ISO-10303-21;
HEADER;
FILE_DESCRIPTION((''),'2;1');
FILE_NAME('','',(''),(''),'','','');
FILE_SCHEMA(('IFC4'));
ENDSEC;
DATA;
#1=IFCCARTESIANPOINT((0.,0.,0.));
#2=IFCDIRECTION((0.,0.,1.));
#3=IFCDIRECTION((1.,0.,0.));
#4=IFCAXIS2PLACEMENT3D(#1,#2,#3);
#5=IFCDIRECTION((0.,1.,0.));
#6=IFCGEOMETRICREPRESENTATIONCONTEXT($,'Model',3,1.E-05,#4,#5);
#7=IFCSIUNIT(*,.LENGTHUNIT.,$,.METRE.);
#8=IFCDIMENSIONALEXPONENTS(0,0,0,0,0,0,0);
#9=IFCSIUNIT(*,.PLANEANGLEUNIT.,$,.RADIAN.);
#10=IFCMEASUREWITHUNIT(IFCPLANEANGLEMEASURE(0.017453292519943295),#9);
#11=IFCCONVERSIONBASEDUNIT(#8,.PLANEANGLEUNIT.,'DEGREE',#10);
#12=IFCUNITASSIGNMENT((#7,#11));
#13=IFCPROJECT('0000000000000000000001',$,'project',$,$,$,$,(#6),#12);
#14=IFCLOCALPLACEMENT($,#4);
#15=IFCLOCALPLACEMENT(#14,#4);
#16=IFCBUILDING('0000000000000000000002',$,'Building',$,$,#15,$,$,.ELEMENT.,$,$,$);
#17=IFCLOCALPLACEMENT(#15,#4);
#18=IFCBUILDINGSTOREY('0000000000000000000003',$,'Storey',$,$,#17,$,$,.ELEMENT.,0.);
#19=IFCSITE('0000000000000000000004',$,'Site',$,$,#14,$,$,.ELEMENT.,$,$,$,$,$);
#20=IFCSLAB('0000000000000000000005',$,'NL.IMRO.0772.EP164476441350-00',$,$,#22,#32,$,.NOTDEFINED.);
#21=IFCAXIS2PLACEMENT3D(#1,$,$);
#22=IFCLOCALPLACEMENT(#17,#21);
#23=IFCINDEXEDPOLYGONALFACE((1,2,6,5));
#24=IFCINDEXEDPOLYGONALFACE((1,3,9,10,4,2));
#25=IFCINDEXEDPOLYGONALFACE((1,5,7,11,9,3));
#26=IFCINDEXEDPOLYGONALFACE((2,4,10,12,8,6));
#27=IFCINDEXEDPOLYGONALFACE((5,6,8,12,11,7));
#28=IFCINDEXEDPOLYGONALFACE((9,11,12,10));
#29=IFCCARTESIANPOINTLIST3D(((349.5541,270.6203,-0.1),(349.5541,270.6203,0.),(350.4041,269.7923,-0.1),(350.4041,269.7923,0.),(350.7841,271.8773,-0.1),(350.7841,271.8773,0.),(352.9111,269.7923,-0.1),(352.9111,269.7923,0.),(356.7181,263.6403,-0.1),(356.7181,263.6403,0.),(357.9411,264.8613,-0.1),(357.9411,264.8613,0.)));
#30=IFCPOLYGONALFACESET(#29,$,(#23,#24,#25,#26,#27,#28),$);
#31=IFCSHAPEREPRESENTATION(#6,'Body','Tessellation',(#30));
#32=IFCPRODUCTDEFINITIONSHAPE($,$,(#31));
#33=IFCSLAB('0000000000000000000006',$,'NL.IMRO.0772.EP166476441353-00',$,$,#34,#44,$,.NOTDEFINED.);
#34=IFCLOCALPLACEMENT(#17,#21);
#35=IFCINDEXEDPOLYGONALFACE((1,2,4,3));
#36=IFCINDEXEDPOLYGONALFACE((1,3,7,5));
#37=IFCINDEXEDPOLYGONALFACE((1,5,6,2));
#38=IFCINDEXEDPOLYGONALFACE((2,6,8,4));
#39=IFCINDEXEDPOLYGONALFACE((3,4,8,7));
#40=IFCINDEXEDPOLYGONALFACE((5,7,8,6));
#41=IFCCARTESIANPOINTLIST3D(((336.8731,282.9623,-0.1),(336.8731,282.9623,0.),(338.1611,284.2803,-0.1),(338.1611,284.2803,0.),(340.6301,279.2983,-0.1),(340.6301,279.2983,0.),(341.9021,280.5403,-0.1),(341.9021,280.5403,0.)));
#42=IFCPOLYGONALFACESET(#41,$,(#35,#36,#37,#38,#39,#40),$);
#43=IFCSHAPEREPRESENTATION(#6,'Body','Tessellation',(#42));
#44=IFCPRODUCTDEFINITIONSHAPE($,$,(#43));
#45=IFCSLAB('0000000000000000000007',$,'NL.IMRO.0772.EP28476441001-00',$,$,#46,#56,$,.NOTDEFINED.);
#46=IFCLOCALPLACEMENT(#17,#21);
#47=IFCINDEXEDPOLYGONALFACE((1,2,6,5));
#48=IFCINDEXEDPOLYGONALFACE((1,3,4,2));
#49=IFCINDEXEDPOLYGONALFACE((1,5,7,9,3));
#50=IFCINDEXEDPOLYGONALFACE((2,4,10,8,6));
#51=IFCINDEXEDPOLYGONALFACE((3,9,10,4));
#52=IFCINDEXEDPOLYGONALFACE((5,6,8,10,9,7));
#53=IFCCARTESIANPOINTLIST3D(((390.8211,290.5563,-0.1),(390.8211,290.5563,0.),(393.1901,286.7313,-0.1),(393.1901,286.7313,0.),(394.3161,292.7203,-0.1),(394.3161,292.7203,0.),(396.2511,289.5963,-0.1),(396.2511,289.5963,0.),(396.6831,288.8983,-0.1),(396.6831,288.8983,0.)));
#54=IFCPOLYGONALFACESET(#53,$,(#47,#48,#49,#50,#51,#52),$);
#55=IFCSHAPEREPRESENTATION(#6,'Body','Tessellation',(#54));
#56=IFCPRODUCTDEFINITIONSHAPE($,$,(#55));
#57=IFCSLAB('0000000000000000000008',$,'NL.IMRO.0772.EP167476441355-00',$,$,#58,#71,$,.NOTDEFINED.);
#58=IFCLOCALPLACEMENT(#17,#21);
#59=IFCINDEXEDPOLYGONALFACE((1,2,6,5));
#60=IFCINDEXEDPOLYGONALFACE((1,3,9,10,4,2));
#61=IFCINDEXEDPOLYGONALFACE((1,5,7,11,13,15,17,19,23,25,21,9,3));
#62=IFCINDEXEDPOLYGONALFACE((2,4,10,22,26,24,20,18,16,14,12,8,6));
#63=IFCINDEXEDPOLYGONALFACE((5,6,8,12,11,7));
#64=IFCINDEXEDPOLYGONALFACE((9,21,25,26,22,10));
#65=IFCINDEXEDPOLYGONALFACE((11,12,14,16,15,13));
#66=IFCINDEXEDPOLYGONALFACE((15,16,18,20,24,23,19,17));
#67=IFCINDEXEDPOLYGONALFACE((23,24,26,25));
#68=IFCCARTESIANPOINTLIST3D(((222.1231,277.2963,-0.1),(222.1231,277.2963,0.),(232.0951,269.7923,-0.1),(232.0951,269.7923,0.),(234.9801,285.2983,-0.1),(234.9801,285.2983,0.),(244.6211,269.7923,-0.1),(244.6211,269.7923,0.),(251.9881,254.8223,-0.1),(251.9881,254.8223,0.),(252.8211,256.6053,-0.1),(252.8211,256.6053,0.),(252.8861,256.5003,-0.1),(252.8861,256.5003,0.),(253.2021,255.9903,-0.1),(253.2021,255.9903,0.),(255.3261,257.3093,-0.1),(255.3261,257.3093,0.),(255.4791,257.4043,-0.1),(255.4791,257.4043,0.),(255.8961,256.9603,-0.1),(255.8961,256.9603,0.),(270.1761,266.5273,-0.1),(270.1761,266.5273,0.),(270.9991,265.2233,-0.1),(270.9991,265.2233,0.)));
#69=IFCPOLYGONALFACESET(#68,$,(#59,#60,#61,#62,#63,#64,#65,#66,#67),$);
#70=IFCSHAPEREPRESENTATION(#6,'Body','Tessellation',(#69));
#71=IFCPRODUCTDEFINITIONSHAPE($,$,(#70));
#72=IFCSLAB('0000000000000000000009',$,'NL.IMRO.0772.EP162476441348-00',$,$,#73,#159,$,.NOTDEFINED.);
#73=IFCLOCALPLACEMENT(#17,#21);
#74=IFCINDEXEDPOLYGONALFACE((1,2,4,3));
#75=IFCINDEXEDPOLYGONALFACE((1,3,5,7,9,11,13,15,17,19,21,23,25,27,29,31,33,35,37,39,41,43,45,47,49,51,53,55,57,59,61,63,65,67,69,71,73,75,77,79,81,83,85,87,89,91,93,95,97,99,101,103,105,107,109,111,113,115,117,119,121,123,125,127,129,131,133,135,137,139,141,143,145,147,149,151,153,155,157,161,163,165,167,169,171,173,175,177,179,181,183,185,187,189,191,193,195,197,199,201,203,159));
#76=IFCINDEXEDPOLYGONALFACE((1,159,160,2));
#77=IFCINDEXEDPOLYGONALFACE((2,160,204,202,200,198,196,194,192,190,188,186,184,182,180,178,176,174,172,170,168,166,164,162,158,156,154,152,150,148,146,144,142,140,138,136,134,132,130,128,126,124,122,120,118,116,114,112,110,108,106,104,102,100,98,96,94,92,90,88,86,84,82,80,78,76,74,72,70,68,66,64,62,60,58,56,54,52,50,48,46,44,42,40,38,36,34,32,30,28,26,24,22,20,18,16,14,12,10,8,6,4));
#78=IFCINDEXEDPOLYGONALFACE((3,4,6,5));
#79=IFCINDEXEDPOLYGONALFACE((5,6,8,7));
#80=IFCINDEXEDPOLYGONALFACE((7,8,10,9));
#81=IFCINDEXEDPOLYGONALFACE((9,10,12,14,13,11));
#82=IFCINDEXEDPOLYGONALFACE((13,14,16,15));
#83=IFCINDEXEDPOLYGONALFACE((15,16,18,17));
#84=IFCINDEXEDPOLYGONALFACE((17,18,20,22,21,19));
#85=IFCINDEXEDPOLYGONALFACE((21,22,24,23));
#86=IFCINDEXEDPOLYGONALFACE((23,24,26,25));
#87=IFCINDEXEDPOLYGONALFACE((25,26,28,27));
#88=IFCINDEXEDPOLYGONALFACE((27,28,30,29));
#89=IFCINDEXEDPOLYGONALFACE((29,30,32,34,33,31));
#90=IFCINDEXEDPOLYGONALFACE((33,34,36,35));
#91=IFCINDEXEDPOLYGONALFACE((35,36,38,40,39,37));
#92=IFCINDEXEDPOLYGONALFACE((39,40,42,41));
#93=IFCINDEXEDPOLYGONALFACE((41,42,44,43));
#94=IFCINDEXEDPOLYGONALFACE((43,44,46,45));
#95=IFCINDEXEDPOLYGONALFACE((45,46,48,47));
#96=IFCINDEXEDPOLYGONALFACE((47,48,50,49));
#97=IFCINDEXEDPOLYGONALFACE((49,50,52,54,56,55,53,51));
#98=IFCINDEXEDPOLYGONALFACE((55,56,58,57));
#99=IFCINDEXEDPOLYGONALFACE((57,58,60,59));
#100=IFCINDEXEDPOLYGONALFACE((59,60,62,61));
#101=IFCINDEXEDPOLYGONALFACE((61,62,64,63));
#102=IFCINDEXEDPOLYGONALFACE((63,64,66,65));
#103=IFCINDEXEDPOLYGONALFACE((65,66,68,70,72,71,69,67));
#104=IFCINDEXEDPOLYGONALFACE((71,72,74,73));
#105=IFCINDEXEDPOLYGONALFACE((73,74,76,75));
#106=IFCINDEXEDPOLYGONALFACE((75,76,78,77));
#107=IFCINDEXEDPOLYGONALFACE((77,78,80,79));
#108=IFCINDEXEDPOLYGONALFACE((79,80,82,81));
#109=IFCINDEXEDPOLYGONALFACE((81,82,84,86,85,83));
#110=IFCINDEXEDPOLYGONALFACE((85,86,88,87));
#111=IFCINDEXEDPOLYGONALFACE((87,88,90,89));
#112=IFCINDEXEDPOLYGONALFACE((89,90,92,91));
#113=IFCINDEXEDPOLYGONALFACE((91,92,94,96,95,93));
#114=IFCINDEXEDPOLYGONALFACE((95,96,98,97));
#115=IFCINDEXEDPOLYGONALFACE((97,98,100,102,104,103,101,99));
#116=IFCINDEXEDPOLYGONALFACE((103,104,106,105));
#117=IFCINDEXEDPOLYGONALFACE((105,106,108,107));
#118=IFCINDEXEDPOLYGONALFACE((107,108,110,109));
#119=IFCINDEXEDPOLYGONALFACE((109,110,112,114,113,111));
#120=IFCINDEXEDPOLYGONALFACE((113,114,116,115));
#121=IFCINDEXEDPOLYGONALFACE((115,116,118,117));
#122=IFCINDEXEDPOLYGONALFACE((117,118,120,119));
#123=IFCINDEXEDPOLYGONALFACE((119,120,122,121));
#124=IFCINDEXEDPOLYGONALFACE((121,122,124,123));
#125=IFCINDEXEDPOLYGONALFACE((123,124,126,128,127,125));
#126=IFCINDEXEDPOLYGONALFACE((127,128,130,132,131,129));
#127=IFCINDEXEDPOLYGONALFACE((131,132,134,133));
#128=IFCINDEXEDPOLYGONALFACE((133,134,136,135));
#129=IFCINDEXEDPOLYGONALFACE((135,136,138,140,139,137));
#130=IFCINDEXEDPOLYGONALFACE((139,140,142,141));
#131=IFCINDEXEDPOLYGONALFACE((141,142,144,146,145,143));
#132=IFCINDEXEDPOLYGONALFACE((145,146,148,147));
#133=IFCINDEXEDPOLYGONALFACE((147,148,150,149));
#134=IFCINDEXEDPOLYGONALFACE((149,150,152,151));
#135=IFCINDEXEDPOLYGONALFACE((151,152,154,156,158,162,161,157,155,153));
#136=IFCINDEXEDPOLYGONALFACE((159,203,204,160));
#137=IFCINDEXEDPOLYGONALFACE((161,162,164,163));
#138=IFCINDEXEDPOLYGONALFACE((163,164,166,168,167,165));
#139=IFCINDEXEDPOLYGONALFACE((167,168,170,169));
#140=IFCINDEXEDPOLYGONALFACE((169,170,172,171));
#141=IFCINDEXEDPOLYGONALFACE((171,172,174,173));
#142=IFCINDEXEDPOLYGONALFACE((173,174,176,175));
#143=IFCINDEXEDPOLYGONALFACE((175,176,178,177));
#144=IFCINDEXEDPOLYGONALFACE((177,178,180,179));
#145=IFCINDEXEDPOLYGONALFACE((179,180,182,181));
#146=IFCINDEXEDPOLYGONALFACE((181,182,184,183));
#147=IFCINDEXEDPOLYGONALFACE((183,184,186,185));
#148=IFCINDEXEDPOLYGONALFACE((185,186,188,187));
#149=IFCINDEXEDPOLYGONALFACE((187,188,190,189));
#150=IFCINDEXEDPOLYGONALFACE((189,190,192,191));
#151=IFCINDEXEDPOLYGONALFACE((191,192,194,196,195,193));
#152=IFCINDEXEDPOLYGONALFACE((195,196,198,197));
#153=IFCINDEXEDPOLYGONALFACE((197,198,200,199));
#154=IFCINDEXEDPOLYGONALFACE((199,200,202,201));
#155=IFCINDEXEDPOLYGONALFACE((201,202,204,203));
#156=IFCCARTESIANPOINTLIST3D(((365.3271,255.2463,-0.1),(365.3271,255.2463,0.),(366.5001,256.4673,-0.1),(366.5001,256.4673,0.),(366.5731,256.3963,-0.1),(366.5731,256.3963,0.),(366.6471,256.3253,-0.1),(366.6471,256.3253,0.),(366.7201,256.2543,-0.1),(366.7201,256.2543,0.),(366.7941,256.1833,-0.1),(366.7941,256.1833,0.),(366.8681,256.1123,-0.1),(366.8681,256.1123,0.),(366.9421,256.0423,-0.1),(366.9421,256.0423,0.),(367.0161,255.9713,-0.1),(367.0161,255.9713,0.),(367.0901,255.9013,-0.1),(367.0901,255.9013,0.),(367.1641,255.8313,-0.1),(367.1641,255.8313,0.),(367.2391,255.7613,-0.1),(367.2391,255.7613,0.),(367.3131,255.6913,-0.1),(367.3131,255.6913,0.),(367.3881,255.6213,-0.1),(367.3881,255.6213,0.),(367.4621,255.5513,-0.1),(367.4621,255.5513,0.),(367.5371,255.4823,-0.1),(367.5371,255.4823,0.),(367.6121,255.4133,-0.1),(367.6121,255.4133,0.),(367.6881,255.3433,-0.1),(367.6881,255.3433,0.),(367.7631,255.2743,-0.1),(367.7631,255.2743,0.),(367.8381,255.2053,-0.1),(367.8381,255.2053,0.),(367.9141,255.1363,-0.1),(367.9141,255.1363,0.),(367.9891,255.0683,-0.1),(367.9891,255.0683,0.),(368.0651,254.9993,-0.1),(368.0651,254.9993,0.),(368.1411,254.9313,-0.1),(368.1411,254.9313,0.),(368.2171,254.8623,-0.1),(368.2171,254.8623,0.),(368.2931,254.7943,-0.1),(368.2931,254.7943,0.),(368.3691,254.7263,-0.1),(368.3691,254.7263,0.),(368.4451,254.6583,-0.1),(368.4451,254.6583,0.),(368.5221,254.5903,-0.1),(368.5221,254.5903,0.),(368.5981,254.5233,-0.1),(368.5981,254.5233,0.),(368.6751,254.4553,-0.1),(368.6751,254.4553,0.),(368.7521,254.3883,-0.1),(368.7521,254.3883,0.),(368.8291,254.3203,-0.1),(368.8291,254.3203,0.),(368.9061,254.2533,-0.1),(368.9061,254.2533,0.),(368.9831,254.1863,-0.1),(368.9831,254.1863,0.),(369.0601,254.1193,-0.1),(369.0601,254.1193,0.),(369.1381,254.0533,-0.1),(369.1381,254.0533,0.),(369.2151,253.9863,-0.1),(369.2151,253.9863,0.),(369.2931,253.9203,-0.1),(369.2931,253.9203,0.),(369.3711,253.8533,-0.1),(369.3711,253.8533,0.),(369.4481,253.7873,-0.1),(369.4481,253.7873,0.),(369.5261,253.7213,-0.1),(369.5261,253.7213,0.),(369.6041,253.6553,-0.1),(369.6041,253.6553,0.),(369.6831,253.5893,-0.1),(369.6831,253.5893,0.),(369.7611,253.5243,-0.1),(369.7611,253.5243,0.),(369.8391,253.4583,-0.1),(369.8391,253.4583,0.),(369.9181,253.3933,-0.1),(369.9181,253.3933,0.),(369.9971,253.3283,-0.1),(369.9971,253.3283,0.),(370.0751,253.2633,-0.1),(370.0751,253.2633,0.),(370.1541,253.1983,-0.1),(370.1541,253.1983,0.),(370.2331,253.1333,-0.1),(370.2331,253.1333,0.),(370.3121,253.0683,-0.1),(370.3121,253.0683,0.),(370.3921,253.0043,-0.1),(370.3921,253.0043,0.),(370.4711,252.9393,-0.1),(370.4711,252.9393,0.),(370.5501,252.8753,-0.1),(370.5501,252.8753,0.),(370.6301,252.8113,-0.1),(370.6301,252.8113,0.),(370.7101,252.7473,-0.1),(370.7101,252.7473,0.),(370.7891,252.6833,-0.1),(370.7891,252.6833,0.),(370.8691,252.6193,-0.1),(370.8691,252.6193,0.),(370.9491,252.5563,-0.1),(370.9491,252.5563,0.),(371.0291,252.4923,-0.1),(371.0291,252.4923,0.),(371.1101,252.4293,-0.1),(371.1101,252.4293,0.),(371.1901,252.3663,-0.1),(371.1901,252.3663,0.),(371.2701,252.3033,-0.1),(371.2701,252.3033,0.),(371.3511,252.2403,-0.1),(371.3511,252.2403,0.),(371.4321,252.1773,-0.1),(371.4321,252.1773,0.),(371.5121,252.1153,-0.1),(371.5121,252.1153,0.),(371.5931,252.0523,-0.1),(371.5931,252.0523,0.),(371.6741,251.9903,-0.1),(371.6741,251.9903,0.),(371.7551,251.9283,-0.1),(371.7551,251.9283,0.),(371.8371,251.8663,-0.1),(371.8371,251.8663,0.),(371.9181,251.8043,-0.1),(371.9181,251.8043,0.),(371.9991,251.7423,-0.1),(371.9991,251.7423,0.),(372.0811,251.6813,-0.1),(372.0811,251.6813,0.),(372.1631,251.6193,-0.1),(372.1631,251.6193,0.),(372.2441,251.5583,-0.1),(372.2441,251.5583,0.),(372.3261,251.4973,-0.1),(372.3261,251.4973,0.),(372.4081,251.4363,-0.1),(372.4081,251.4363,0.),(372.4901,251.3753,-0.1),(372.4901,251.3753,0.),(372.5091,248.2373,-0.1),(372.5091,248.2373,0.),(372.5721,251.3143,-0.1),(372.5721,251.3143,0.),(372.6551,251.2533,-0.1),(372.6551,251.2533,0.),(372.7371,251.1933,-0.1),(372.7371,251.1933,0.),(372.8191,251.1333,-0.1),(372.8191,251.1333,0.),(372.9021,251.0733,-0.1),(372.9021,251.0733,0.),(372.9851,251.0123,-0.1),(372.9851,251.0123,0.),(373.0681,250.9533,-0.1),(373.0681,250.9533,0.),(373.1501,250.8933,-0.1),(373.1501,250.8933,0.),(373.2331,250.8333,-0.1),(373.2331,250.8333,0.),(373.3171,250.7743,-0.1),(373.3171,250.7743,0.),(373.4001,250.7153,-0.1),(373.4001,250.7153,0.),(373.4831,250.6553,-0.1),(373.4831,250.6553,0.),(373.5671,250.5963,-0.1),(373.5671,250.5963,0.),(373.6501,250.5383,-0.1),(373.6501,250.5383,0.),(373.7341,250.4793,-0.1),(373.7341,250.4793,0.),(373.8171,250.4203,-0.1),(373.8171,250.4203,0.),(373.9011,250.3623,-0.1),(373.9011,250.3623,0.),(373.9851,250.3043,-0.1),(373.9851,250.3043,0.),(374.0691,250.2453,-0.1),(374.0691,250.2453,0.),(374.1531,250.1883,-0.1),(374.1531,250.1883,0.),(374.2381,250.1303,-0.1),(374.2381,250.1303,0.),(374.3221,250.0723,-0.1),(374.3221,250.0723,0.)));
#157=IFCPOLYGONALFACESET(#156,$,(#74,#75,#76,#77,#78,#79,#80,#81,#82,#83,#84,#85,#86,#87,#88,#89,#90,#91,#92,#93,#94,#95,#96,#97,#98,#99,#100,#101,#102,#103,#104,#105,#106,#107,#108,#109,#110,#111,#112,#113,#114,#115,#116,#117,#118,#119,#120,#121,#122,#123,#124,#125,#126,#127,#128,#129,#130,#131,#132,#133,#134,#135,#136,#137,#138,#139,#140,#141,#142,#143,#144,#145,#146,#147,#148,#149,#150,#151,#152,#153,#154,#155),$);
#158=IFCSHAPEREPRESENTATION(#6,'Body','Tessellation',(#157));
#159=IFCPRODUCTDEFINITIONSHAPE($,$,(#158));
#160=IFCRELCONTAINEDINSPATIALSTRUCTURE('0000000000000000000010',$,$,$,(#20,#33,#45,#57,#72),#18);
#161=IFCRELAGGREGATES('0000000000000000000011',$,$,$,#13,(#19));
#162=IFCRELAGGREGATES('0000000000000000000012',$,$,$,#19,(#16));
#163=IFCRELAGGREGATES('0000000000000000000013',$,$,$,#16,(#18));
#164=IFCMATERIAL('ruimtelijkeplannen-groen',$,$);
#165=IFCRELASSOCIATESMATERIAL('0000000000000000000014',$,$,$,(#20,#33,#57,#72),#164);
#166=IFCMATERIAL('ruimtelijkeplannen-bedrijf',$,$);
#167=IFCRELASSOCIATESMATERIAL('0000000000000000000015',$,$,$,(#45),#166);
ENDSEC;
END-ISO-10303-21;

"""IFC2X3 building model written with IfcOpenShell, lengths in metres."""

from ifc_helpers import new_model, entity, si_unit, converted_unit, direction, frame, origin_with_axes, place, context, project, spatial, polyline, outline, extrude, material, element, save


model = new_model("IFC2X3")

# Units and contexts
model_context = context("Model", 3, precision=1e-05, world=origin_with_axes(), true_north=direction((0.0, 1.0, 0.0)))
ifc_project = project(units=[si_unit("LENGTHUNIT", "METRE"), converted_unit("PLANEANGLEUNIT", "DEGREE", entity("IfcPlaneAngleMeasure", 0.017453292519943295), si_unit("PLANEANGLEUNIT", "RADIAN"), dimensions=[0, 0, 0, 0, 0, 0, 0])], contexts=[model_context])

# Site, building, storey
site_placement = place(None, origin_with_axes())
site = spatial("IfcSite", under=ifc_project, at=site_placement, Name="Site", CompositionType="ELEMENT")
building_placement = place(site_placement, origin_with_axes())
building = spatial("IfcBuilding", under=site, at=building_placement, Name="Building", CompositionType="ELEMENT")
storey_placement = place(building_placement, origin_with_axes())
storey = spatial("IfcBuildingStorey", under=building, at=storey_placement, Name="Storey", CompositionType="ELEMENT", Elevation=0.0)

# Slabs
ifc_material_1 = material(Name="ruimtelijkeplannen-groen")
slab_1_placement = place(storey_placement, frame((0.0, 0.0, -0.1), z_axis=(0.0, 0.0, 1.0), x_axis=(1.0, 0.0, 0.0)))
element("IfcSlab", 1, at=slab_1_placement, inside=storey, material=ifc_material_1, Name="NL.IMRO.0772.EP164476441350-00", PredefinedType="NOTDEFINED", context=model_context, shape_type="SweptSolid", body=[
    extrude(outline(polyline([(350.4041, 269.7923), (349.5541, 270.6203), (350.7841, 271.8773), (352.9111, 269.7923), (357.9411, 264.8613), (356.7181, 263.6403), (350.4041, 269.7923)])), origin_with_axes(), (0.0, 0.0, 1.0), 0.1),
])
slab_2_placement = place(storey_placement, frame((0.0, 0.0, -0.1), z_axis=(0.0, 0.0, 1.0), x_axis=(1.0, 0.0, 0.0)))
element("IfcSlab", 2, at=slab_2_placement, inside=storey, material=ifc_material_1, Name="NL.IMRO.0772.EP166476441353-00", PredefinedType="NOTDEFINED", context=model_context, shape_type="SweptSolid", body=[
    extrude(outline(polyline([(338.1611, 284.2803), (341.9021, 280.5403), (340.6301, 279.2983), (336.8731, 282.9623), (338.1611, 284.2803)])), origin_with_axes(), (0.0, 0.0, 1.0), 0.1),
])
ifc_material_2 = material(Name="ruimtelijkeplannen-bedrijf")
slab_3_placement = place(storey_placement, frame((0.0, 0.0, -0.1), z_axis=(0.0, 0.0, 1.0), x_axis=(1.0, 0.0, 0.0)))
element("IfcSlab", 3, at=slab_3_placement, inside=storey, material=ifc_material_2, Name="NL.IMRO.0772.EP28476441001-00", PredefinedType="NOTDEFINED", context=model_context, shape_type="SweptSolid", body=[
    extrude(outline(polyline([(396.2511, 289.5963), (396.6831, 288.8983), (393.1901, 286.7313), (390.8211, 290.5563), (394.3161, 292.7203), (396.2511, 289.5963)])), origin_with_axes(), (0.0, 0.0, 1.0), 0.1),
])
slab_4_placement = place(storey_placement, frame((0.0, 0.0, -0.1), z_axis=(0.0, 0.0, 1.0), x_axis=(1.0, 0.0, 0.0)))
element("IfcSlab", 4, at=slab_4_placement, inside=storey, material=ifc_material_1, Name="NL.IMRO.0772.EP167476441355-00", PredefinedType="NOTDEFINED", context=model_context, shape_type="SweptSolid", body=[
    extrude(outline(polyline([(222.1231, 277.2963), (234.9801, 285.2983), (244.6211, 269.7923), (252.8211, 256.6053), (252.8861, 256.5003), (253.2021, 255.9903), (255.3261, 257.3093), (255.4791, 257.4043), (270.1761, 266.5273), (270.9991, 265.2233), (255.8961, 256.9603), (251.9881, 254.8223), (232.0951, 269.7923), (222.1231, 277.2963)])), origin_with_axes(), (0.0, 0.0, 1.0), 0.1),
])
slab_5_placement = place(storey_placement, frame((0.0, 0.0, -0.1), z_axis=(0.0, 0.0, 1.0), x_axis=(1.0, 0.0, 0.0)))
element("IfcSlab", 5, at=slab_5_placement, inside=storey, material=ifc_material_1, Name="NL.IMRO.0772.EP162476441348-00", PredefinedType="NOTDEFINED", context=model_context, shape_type="SweptSolid", body=[
    extrude(outline(polyline([(366.5731, 256.3963), (366.6471, 256.3253), (366.7201, 256.2543), (366.7941, 256.1833), (366.8681, 256.1123), (366.9421, 256.0423), (367.0161, 255.9713), (367.0901, 255.9013), (367.1641, 255.8313), (367.2391, 255.7613), (367.3131, 255.6913), (367.3881, 255.6213), (367.4621, 255.5513), (367.5371, 255.4823), (367.6121, 255.4133), (367.6881, 255.3433), (367.7631, 255.2743), (367.8381, 255.2053), (367.9141, 255.1363), (367.9891, 255.0683), (368.0651, 254.9993), (368.1411, 254.9313), (368.2171, 254.8623), (368.2931, 254.7943), (368.3691, 254.7263), (368.4451, 254.6583), (368.5221, 254.5903), (368.5981, 254.5233), (368.6751, 254.4553), (368.7521, 254.3883), (368.8291, 254.3203), (368.9061, 254.2533), (368.9831, 254.1863), (369.0601, 254.1193), (369.1381, 254.0533), (369.2151, 253.9863), (369.2931, 253.9203), (369.3711, 253.8533), (369.4481, 253.7873), (369.5261, 253.7213), (369.6041, 253.6553), (369.6831, 253.5893), (369.7611, 253.5243), (369.8391, 253.4583), (369.9181, 253.3933), (369.9971, 253.3283), (370.0751, 253.2633), (370.1541, 253.1983), (370.2331, 253.1333), (370.3121, 253.0683), (370.3921, 253.0043), (370.4711, 252.9393), (370.5501, 252.8753), (370.6301, 252.8113), (370.7101, 252.7473), (370.7891, 252.6833), (370.8691, 252.6193), (370.9491, 252.5563), (371.0291, 252.4923), (371.1101, 252.4293), (371.1901, 252.3663), (371.2701, 252.3033), (371.3511, 252.2403), (371.4321, 252.1773), (371.5121, 252.1153), (371.5931, 252.0523), (371.6741, 251.9903), (371.7551, 251.9283), (371.8371, 251.8663), (371.9181, 251.8043), (371.9991, 251.7423), (372.0811, 251.6813), (372.1631, 251.6193), (372.2441, 251.5583), (372.3261, 251.4973), (372.4081, 251.4363), (372.4901, 251.3753), (372.5721, 251.3143), (372.6551, 251.2533), (372.7371, 251.1933), (372.8191, 251.1333), (372.9021, 251.0733), (372.9851, 251.0123), (373.0681, 250.9533), (373.1501, 250.8933), (373.2331, 250.8333), (373.3171, 250.7743), (373.4001, 250.7153), (373.4831, 250.6553), (373.5671, 250.5963), (373.6501, 250.5383), (373.7341, 250.4793), (373.8171, 250.4203), (373.9011, 250.3623), (373.9851, 250.3043), (374.0691, 250.2453), (374.1531, 250.1883), (374.2381, 250.1303), (374.3221, 250.0723), (372.5091, 248.2373), (365.3271, 255.2463), (366.5001, 256.4673), (366.5731, 256.3963)])), origin_with_axes(), (0.0, 0.0, 1.0), 0.1),
])

save(model, "model.ifc")
